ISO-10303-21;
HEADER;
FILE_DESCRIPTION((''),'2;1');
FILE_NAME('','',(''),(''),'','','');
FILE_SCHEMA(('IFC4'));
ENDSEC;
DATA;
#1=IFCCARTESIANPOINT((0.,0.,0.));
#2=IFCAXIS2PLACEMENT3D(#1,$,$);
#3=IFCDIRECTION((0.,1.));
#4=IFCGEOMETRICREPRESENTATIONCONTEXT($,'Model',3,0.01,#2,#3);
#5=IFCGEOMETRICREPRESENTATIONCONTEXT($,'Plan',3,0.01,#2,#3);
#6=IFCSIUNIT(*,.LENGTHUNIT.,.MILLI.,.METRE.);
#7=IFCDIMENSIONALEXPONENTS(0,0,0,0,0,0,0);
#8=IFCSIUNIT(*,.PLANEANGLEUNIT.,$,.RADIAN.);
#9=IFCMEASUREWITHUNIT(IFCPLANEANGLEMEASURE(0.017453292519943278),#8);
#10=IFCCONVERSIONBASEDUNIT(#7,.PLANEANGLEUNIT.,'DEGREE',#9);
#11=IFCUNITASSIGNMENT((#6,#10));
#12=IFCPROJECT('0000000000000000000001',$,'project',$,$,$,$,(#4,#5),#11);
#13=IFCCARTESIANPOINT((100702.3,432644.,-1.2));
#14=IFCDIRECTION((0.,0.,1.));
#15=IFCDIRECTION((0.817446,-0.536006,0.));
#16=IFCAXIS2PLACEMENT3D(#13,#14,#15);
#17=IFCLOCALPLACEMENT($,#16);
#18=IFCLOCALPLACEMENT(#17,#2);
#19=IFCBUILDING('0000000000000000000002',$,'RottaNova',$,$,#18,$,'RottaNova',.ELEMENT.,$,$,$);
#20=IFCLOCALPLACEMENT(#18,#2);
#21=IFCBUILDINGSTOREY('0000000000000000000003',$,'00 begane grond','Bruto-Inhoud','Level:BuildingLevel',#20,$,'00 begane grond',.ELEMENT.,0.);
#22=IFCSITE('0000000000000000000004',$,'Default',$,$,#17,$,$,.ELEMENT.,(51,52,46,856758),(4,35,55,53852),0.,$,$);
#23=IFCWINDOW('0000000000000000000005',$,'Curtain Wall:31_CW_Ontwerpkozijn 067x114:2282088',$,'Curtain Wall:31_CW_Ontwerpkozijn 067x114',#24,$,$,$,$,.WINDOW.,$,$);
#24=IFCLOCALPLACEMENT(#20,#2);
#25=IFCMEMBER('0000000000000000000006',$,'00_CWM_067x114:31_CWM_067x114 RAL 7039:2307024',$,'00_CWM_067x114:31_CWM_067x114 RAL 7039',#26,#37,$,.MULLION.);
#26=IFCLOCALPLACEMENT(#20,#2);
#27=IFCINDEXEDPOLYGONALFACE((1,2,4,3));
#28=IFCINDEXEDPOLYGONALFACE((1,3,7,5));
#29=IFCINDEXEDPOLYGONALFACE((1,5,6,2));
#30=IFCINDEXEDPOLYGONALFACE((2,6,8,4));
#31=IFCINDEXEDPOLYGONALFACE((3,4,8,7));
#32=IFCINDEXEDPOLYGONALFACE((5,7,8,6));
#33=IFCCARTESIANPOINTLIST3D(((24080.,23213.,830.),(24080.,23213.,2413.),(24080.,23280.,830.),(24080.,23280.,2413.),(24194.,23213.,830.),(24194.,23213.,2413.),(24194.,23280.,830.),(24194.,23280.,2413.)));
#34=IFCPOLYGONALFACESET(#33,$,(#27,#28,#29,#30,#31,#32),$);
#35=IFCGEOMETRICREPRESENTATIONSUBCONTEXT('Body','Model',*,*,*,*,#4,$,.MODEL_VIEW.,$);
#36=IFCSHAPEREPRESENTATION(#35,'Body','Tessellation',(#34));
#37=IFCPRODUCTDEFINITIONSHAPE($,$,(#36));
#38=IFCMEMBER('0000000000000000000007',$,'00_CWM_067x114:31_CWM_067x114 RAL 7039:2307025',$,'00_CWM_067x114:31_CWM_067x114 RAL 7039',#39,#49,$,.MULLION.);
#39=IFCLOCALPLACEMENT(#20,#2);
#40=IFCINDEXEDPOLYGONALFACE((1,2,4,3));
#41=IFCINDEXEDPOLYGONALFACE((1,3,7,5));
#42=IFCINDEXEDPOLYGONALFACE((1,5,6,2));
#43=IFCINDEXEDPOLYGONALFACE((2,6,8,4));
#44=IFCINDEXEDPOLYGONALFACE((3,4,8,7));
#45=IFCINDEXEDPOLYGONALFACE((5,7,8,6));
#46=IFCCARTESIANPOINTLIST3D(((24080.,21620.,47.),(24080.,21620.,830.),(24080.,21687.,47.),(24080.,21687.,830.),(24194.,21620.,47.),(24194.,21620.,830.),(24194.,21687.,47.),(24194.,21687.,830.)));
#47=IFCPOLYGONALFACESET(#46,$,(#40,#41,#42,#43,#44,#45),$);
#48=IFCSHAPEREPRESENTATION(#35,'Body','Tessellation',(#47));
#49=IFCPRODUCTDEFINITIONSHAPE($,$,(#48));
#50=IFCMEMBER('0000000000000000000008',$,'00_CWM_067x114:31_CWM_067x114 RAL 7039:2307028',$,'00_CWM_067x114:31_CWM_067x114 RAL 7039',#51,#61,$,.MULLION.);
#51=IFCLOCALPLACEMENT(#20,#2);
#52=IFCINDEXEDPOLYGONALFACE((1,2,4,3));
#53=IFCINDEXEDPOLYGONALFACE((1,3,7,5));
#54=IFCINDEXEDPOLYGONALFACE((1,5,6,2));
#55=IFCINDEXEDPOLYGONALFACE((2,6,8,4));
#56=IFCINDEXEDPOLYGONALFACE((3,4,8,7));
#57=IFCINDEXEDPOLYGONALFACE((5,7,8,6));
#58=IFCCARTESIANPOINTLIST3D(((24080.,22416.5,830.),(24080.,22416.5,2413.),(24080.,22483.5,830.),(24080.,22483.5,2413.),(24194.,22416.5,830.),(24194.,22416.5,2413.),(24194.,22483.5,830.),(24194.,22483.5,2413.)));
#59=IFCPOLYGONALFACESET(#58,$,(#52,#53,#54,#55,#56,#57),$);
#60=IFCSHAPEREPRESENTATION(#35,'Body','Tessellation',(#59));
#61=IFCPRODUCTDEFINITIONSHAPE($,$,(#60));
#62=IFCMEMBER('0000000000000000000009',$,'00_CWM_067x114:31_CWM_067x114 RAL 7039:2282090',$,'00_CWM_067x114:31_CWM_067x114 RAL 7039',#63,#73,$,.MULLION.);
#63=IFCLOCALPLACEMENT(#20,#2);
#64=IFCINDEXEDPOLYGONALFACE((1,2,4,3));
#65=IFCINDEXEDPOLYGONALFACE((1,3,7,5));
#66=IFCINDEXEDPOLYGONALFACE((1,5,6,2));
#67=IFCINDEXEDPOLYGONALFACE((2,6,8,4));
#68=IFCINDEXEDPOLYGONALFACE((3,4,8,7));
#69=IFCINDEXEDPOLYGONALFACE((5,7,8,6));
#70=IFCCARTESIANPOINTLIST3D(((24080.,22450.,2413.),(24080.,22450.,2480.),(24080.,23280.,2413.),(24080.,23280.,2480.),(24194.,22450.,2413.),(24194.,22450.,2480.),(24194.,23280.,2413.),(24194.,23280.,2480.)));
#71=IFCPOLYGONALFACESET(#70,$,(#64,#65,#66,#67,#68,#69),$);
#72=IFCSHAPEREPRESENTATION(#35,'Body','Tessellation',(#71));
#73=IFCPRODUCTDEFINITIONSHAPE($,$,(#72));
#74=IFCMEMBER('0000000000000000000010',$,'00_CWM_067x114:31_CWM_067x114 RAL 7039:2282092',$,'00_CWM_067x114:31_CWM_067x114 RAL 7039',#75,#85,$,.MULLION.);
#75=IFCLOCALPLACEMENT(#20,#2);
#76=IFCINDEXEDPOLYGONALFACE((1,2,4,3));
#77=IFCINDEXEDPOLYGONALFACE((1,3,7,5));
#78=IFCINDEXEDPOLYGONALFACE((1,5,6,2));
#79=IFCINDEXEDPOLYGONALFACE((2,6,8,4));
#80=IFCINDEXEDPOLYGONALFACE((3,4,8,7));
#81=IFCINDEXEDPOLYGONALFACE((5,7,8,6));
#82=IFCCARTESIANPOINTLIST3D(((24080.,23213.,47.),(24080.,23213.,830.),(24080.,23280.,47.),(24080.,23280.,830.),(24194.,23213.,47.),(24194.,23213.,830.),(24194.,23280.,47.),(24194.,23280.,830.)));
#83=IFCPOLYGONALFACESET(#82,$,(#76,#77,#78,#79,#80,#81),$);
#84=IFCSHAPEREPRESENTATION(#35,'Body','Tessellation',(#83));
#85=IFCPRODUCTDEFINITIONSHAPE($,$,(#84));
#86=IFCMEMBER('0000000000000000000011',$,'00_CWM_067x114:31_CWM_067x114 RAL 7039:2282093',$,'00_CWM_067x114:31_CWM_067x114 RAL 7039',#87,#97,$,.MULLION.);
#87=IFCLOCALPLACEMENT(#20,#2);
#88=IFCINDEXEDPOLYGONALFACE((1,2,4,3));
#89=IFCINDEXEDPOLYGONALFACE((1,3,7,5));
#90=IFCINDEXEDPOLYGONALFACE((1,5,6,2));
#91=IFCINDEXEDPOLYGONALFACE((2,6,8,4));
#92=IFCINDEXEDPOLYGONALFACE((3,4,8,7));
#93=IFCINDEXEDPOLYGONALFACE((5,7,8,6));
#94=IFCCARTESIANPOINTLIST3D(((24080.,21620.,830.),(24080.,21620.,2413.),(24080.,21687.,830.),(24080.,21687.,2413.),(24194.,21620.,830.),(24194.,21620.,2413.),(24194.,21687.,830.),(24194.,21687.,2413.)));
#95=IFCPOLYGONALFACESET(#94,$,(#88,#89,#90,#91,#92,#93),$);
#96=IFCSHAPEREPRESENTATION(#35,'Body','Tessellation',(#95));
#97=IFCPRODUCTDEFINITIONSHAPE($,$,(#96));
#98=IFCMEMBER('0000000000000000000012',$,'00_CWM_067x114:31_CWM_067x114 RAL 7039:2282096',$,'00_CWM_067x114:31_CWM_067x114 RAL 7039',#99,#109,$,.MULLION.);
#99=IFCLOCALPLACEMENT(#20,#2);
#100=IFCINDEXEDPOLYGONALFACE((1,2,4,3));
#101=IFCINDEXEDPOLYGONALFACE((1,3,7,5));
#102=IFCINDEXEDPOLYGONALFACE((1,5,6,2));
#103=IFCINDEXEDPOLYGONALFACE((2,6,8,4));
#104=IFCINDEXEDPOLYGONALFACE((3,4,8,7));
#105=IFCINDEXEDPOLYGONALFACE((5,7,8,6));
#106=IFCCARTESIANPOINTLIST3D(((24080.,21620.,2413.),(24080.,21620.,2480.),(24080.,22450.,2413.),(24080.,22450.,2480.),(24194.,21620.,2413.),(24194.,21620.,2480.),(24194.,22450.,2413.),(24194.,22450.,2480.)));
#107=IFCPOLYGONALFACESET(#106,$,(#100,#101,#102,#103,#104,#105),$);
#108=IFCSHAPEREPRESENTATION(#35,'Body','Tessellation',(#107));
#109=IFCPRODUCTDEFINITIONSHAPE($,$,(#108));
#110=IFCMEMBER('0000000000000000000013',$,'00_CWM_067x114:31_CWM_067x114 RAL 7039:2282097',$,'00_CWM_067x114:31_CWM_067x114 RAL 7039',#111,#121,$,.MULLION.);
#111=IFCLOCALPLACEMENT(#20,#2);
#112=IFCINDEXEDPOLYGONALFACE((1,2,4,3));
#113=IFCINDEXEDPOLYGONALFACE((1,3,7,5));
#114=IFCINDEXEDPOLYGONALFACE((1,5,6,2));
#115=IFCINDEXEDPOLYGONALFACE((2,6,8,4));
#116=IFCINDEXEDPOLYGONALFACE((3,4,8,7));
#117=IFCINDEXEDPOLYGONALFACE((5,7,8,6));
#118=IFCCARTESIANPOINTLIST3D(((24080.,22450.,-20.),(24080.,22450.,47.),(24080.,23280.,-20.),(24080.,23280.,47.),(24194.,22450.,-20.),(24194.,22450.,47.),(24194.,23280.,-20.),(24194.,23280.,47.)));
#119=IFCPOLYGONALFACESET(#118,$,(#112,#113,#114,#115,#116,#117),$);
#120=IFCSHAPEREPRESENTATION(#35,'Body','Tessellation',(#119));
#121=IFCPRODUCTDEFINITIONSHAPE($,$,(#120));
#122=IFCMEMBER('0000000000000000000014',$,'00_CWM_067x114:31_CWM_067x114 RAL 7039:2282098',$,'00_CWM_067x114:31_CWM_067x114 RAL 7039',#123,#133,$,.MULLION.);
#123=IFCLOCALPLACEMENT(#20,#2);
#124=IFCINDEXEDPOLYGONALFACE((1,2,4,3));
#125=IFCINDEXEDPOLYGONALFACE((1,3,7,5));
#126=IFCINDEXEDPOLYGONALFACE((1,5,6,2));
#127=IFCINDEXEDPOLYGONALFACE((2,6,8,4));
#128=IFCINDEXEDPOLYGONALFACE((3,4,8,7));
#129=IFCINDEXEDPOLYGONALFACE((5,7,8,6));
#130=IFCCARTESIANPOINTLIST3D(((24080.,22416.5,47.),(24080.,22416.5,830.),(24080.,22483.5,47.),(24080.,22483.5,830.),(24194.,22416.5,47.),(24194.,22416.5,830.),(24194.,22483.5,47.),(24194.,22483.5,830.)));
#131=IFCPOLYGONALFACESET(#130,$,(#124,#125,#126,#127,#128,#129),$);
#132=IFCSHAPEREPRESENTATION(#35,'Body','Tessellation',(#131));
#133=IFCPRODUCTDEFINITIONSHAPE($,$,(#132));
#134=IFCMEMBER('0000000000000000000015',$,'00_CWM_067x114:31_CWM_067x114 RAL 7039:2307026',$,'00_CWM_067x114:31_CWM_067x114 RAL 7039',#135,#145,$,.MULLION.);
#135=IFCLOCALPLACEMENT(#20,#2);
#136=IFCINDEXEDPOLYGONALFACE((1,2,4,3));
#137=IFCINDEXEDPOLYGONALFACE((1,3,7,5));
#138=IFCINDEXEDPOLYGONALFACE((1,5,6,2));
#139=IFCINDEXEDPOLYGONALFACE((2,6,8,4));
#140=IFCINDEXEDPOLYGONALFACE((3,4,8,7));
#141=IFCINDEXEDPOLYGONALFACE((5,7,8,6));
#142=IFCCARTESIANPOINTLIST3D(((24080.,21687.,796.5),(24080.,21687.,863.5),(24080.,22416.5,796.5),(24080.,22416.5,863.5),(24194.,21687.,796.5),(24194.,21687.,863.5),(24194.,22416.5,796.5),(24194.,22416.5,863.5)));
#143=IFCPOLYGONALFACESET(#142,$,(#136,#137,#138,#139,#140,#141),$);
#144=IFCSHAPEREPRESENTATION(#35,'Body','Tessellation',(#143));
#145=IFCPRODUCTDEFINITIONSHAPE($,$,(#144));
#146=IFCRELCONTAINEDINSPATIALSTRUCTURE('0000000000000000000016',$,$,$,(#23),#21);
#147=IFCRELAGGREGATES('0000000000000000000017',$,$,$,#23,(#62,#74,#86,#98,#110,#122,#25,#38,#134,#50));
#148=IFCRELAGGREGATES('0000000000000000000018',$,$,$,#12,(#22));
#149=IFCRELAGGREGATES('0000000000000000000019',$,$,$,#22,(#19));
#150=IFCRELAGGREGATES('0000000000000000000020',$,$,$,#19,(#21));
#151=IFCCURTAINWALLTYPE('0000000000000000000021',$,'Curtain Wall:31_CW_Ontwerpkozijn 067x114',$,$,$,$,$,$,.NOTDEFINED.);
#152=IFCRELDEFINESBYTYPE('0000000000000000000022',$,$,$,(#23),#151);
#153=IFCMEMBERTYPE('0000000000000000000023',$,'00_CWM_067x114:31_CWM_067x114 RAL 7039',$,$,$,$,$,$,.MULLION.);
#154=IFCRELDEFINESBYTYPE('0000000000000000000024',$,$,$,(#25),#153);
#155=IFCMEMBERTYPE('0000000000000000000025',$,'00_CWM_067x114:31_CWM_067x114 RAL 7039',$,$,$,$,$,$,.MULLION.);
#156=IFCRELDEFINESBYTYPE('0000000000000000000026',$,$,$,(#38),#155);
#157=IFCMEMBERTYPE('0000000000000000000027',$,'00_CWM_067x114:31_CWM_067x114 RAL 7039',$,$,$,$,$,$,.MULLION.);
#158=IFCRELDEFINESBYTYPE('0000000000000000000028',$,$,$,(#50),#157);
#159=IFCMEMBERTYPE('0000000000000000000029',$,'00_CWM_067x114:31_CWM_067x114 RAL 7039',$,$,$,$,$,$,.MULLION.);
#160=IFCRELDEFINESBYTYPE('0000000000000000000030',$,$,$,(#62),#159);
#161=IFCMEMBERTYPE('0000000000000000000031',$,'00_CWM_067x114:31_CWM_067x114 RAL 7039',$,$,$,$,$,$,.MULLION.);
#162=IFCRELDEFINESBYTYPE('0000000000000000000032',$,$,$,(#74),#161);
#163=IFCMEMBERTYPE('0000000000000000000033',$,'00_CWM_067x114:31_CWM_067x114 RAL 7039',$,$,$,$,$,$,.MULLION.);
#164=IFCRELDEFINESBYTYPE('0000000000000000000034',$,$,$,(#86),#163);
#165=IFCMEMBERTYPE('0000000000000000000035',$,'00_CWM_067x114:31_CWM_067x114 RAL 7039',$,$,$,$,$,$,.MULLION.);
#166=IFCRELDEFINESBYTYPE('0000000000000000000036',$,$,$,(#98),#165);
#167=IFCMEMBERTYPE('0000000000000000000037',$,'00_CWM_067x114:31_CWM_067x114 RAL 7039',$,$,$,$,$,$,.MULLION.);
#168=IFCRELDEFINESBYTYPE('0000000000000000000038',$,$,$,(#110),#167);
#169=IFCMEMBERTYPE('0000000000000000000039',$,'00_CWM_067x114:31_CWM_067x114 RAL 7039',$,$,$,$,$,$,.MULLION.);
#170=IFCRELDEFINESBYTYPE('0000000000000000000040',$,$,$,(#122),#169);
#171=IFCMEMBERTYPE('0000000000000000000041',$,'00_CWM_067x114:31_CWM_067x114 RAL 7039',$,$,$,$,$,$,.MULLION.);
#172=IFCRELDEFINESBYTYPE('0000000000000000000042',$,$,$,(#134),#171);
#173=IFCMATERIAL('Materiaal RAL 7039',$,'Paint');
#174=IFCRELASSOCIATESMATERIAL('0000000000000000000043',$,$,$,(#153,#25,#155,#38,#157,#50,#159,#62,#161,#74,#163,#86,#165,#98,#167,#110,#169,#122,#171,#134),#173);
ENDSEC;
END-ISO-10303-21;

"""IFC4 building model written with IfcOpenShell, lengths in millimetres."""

from ifc_helpers import new_model, entity, si_unit, converted_unit, direction, frame, origin, place, context, subcontext, project, spatial, indexed_curve, outline, extrude, source, transform, mapped, material, type_object, type_shapes, element, aggregate, save


model = new_model("IFC4")

# Units and contexts
model_context = context("Model", 3, precision=0.01, world=origin(), true_north=direction((0.0, 1.0)))
plan_context = context("Plan", 3, precision=0.01, world=origin(), true_north=direction((0.0, 1.0)))
body_context = subcontext(model_context, "Body", "Model", "MODEL_VIEW")
ifc_project = project(units=[si_unit("LENGTHUNIT", "METRE", prefix="MILLI"), converted_unit("PLANEANGLEUNIT", "DEGREE", entity("IfcPlaneAngleMeasure", 0.017453292519943278), si_unit("PLANEANGLEUNIT", "RADIAN"), dimensions=[0, 0, 0, 0, 0, 0, 0])], contexts=[model_context, plan_context])

# Site, building, storey
site_placement = place(None, frame((100702.3, 432644.0, -1.2), z_axis=(0.0, 0.0, 1.0), x_axis=(0.817446, -0.536006, 0.0)))
site = spatial("IfcSite", under=ifc_project, at=site_placement, Name="Default", CompositionType="ELEMENT", RefLatitude=(51, 52, 46, 856758), RefLongitude=(4, 35, 55, 53852), RefElevation=0.0)
building_placement = place(site_placement, origin())
building = spatial("IfcBuilding", under=site, at=building_placement, Name="RottaNova", LongName="RottaNova", CompositionType="ELEMENT")
storey_placement = place(building_placement, origin())
storey = spatial("IfcBuildingStorey", under=building, at=storey_placement, Name="00 begane grond", Description="Bruto-Inhoud", ObjectType="Level:BuildingLevel", LongName="00 begane grond", CompositionType="ELEMENT", Elevation=0.0)

# Window, members
curtain_wall_type = type_object("IfcCurtainWallType", Name="Curtain Wall:31_CW_Ontwerpkozijn 067x114", PredefinedType="NOTDEFINED")
window_placement = place(storey_placement, origin())
window = element("IfcWindow", 1, at=window_placement, inside=storey, type_object=curtain_wall_type, Name="Curtain Wall:31_CW_Ontwerpkozijn 067x114:2282088", ObjectType="Curtain Wall:31_CW_Ontwerpkozijn 067x114", PredefinedType="WINDOW")
ifc_material_1 = material(Name="Materiaal RAL 7039", Category="Paint")
member_type_1 = type_object("IfcMemberType", Name="00_CWM_067x114:31_CWM_067x114 RAL 7039", PredefinedType="MULLION", material=ifc_material_1)
shared_shape_1 = source(origin(), body_context, "Body", "SweptSolid", [
    extrude(outline(indexed_curve([(-33.5, -57.0), (33.5, -57.0), (33.5, 57.0), (-33.5, 57.0), (-33.5, -57.0)], self_intersect=False)), frame((-33.5, 57.0, -1583.0), z_axis=(0.0, 0.0, 1.0), x_axis=(-1.0, 0.0, 0.0)), (0.0, 0.0, 1.0), 1583.0),
])
type_shapes(member_type_1, [shared_shape_1])
member_1_placement = place(window_placement, frame((24080.0, 23280.0, 830.0), z_axis=(0.0, 0.0, -1.0), x_axis=(0.0, 1.0, 0.0)))
member_1 = element("IfcMember", 2, at=member_1_placement, type_object=member_type_1, material=ifc_material_1, Name="00_CWM_067x114:31_CWM_067x114 RAL 7039:2307024", ObjectType="00_CWM_067x114:31_CWM_067x114 RAL 7039", PredefinedType="MULLION", context=body_context, shape_type="MappedRepresentation", body=[
    mapped(shared_shape_1, transform((0.0, 0.0, 0.0), scale=1.0)),
])
member_type_2 = type_object("IfcMemberType", Name="00_CWM_067x114:31_CWM_067x114 RAL 7039", PredefinedType="MULLION", material=ifc_material_1)
shared_shape_2 = source(origin(), body_context, "Body", "SweptSolid", [
    extrude(outline(indexed_curve([(-33.5, -57.0), (33.5, -57.0), (33.5, 57.0), (-33.5, 57.0), (-33.5, -57.0)], self_intersect=False)), frame((-33.5, 57.0, -783.0), z_axis=(0.0, 0.0, 1.0), x_axis=(-1.0, 0.0, 0.0)), (0.0, 0.0, 1.0), 783.0),
])
type_shapes(member_type_2, [shared_shape_2])
member_2_placement = place(window_placement, frame((24080.0, 21620.0, 830.0), z_axis=(0.0, 0.0, 1.0), x_axis=(0.0, -1.0, 0.0)))
member_2 = element("IfcMember", 3, at=member_2_placement, type_object=member_type_2, material=ifc_material_1, Name="00_CWM_067x114:31_CWM_067x114 RAL 7039:2307025", ObjectType="00_CWM_067x114:31_CWM_067x114 RAL 7039", PredefinedType="MULLION", context=body_context, shape_type="MappedRepresentation", body=[
    mapped(shared_shape_2, transform((0.0, 0.0, 0.0), scale=1.0)),
])
member_type_3 = type_object("IfcMemberType", Name="00_CWM_067x114:31_CWM_067x114 RAL 7039", PredefinedType="MULLION", material=ifc_material_1)
shared_shape_3 = source(origin(), body_context, "Body", "SweptSolid", [
    extrude(outline(indexed_curve([(-33.5, -57.0), (33.5, -57.0), (33.5, 57.0), (-33.5, 57.0), (-33.5, -57.0)], self_intersect=False)), frame((0.0, 57.0, -1583.0), z_axis=(0.0, 0.0, 1.0), x_axis=(-1.0, 0.0, 0.0)), (0.0, 0.0, 1.0), 1583.0),
])
type_shapes(member_type_3, [shared_shape_3])
member_3_placement = place(window_placement, frame((24080.0, 22450.0, 830.0), z_axis=(0.0, 0.0, -1.0), x_axis=(0.0, 1.0, 0.0)))
member_3 = element("IfcMember", 4, at=member_3_placement, type_object=member_type_3, material=ifc_material_1, Name="00_CWM_067x114:31_CWM_067x114 RAL 7039:2307028", ObjectType="00_CWM_067x114:31_CWM_067x114 RAL 7039", PredefinedType="MULLION", context=body_context, shape_type="MappedRepresentation", body=[
    mapped(shared_shape_3, transform((0.0, 0.0, 0.0), scale=1.0)),
])
member_type_4 = type_object("IfcMemberType", Name="00_CWM_067x114:31_CWM_067x114 RAL 7039", PredefinedType="MULLION", material=ifc_material_1)
shared_shape_4 = source(origin(), body_context, "Body", "SweptSolid", [
    extrude(outline(indexed_curve([(-33.5, -57.0), (33.5, -57.0), (33.5, 57.0), (-33.5, 57.0), (-33.5, -57.0)], self_intersect=False)), frame((-33.5, 57.0, -830.0), z_axis=(0.0, 0.0, 1.0), x_axis=(-1.0, 0.0, 0.0)), (0.0, 0.0, 1.0), 830.0),
])
type_shapes(member_type_4, [shared_shape_4])
member_4_placement = place(window_placement, frame((24080.0, 23280.0, 2480.0), z_axis=(0.0, 1.0, 0.0), x_axis=(0.0, 0.0, 1.0)))
member_4 = element("IfcMember", 5, at=member_4_placement, type_object=member_type_4, material=ifc_material_1, Name="00_CWM_067x114:31_CWM_067x114 RAL 7039:2282090", ObjectType="00_CWM_067x114:31_CWM_067x114 RAL 7039", PredefinedType="MULLION", context=body_context, shape_type="MappedRepresentation", body=[
    mapped(shared_shape_4, transform((0.0, 0.0, 0.0), scale=1.0)),
])
member_type_5 = type_object("IfcMemberType", Name="00_CWM_067x114:31_CWM_067x114 RAL 7039", PredefinedType="MULLION", material=ifc_material_1)
shared_shape_5 = source(origin(), body_context, "Body", "SweptSolid", [
    extrude(outline(indexed_curve([(-33.5, -57.0), (33.5, -57.0), (33.5, 57.0), (-33.5, 57.0), (-33.5, -57.0)], self_intersect=False)), frame((-33.5, 57.0, -783.0), z_axis=(0.0, 0.0, 1.0), x_axis=(-1.0, 0.0, 0.0)), (0.0, 0.0, 1.0), 783.0),
])
type_shapes(member_type_5, [shared_shape_5])
member_5_placement = place(window_placement, frame((24080.0, 23280.0, 47.0), z_axis=(0.0, 0.0, -1.0), x_axis=(0.0, 1.0, 0.0)))
member_5 = element("IfcMember", 6, at=member_5_placement, type_object=member_type_5, material=ifc_material_1, Name="00_CWM_067x114:31_CWM_067x114 RAL 7039:2282092", ObjectType="00_CWM_067x114:31_CWM_067x114 RAL 7039", PredefinedType="MULLION", context=body_context, shape_type="MappedRepresentation", body=[
    mapped(shared_shape_5, transform((0.0, 0.0, 0.0), scale=1.0)),
])
member_type_6 = type_object("IfcMemberType", Name="00_CWM_067x114:31_CWM_067x114 RAL 7039", PredefinedType="MULLION", material=ifc_material_1)
shared_shape_6 = source(origin(), body_context, "Body", "SweptSolid", [
    extrude(outline(indexed_curve([(-33.5, -57.0), (33.5, -57.0), (33.5, 57.0), (-33.5, 57.0), (-33.5, -57.0)], self_intersect=False)), frame((-33.5, 57.0, -1583.0), z_axis=(0.0, 0.0, 1.0), x_axis=(-1.0, 0.0, 0.0)), (0.0, 0.0, 1.0), 1583.0),
])
type_shapes(member_type_6, [shared_shape_6])
member_6_placement = place(window_placement, frame((24080.0, 21620.0, 2413.0), z_axis=(0.0, 0.0, 1.0), x_axis=(0.0, -1.0, 0.0)))
member_6 = element("IfcMember", 7, at=member_6_placement, type_object=member_type_6, material=ifc_material_1, Name="00_CWM_067x114:31_CWM_067x114 RAL 7039:2282093", ObjectType="00_CWM_067x114:31_CWM_067x114 RAL 7039", PredefinedType="MULLION", context=body_context, shape_type="MappedRepresentation", body=[
    mapped(shared_shape_6, transform((0.0, 0.0, 0.0), scale=1.0)),
])
member_type_7 = type_object("IfcMemberType", Name="00_CWM_067x114:31_CWM_067x114 RAL 7039", PredefinedType="MULLION", material=ifc_material_1)
shared_shape_7 = source(origin(), body_context, "Body", "SweptSolid", [
    extrude(outline(indexed_curve([(-33.5, -57.0), (33.5, -57.0), (33.5, 57.0), (-33.5, 57.0), (-33.5, -57.0)], self_intersect=False)), frame((-33.5, 57.0, -830.0), z_axis=(0.0, 0.0, 1.0), x_axis=(-1.0, 0.0, 0.0)), (0.0, 0.0, 1.0), 830.0),
])
type_shapes(member_type_7, [shared_shape_7])
member_7_placement = place(window_placement, frame((24080.0, 22450.0, 2480.0), z_axis=(0.0, 1.0, 0.0), x_axis=(0.0, 0.0, 1.0)))
member_7 = element("IfcMember", 8, at=member_7_placement, type_object=member_type_7, material=ifc_material_1, Name="00_CWM_067x114:31_CWM_067x114 RAL 7039:2282096", ObjectType="00_CWM_067x114:31_CWM_067x114 RAL 7039", PredefinedType="MULLION", context=body_context, shape_type="MappedRepresentation", body=[
    mapped(shared_shape_7, transform((0.0, 0.0, 0.0), scale=1.0)),
])
member_type_8 = type_object("IfcMemberType", Name="00_CWM_067x114:31_CWM_067x114 RAL 7039", PredefinedType="MULLION", material=ifc_material_1)
shared_shape_8 = source(origin(), body_context, "Body", "SweptSolid", [
    extrude(outline(indexed_curve([(-33.5, -57.0), (33.5, -57.0), (33.5, 57.0), (-33.5, 57.0), (-33.5, -57.0)], self_intersect=False)), frame((-33.5, 57.0, -830.0), z_axis=(0.0, 0.0, 1.0), x_axis=(-1.0, 0.0, 0.0)), (0.0, 0.0, 1.0), 830.0),
])
type_shapes(member_type_8, [shared_shape_8])
member_8_placement = place(window_placement, frame((24080.0, 22450.0, -20.0), z_axis=(0.0, -1.0, 0.0), x_axis=(0.0, 0.0, -1.0)))
member_8 = element("IfcMember", 9, at=member_8_placement, type_object=member_type_8, material=ifc_material_1, Name="00_CWM_067x114:31_CWM_067x114 RAL 7039:2282097", ObjectType="00_CWM_067x114:31_CWM_067x114 RAL 7039", PredefinedType="MULLION", context=body_context, shape_type="MappedRepresentation", body=[
    mapped(shared_shape_8, transform((0.0, 0.0, 0.0), scale=1.0)),
])
member_type_9 = type_object("IfcMemberType", Name="00_CWM_067x114:31_CWM_067x114 RAL 7039", PredefinedType="MULLION", material=ifc_material_1)
shared_shape_9 = source(origin(), body_context, "Body", "SweptSolid", [
    extrude(outline(indexed_curve([(-33.5, -57.0), (33.5, -57.0), (33.5, 57.0), (-33.5, 57.0), (-33.5, -57.0)], self_intersect=False)), frame((0.0, 57.0, -783.0), z_axis=(0.0, 0.0, 1.0), x_axis=(-1.0, 0.0, 0.0)), (0.0, 0.0, 1.0), 783.0),
])
type_shapes(member_type_9, [shared_shape_9])
member_9_placement = place(window_placement, frame((24080.0, 22450.0, 47.0), z_axis=(0.0, 0.0, -1.0), x_axis=(0.0, 1.0, 0.0)))
member_9 = element("IfcMember", 10, at=member_9_placement, type_object=member_type_9, material=ifc_material_1, Name="00_CWM_067x114:31_CWM_067x114 RAL 7039:2282098", ObjectType="00_CWM_067x114:31_CWM_067x114 RAL 7039", PredefinedType="MULLION", context=body_context, shape_type="MappedRepresentation", body=[
    mapped(shared_shape_9, transform((0.0, 0.0, 0.0), scale=1.0)),
])
member_type_10 = type_object("IfcMemberType", Name="00_CWM_067x114:31_CWM_067x114 RAL 7039", PredefinedType="MULLION", material=ifc_material_1)
shared_shape_10 = source(origin(), body_context, "Body", "SweptSolid", [
    extrude(outline(indexed_curve([(-33.5, -57.0), (33.5, -57.0), (33.5, 57.0), (-33.5, 57.0), (-33.5, -57.0)], self_intersect=False)), frame((0.0, 57.0, -729.5), z_axis=(0.0, 0.0, 1.0), x_axis=(-1.0, 0.0, 0.0)), (0.0, 0.0, 1.0), 729.5),
])
type_shapes(member_type_10, [shared_shape_10])
member_10_placement = place(window_placement, frame((24080.0, 22416.5, 830.0), z_axis=(0.0, 1.0, 0.0), x_axis=(0.0, 0.0, 1.0)))
member_10 = element("IfcMember", 11, at=member_10_placement, type_object=member_type_10, material=ifc_material_1, Name="00_CWM_067x114:31_CWM_067x114 RAL 7039:2307026", ObjectType="00_CWM_067x114:31_CWM_067x114 RAL 7039", PredefinedType="MULLION", context=body_context, shape_type="MappedRepresentation", body=[
    mapped(shared_shape_10, transform((0.0, 0.0, 0.0), scale=1.0)),
])
aggregate(window, [member_4, member_5, member_6, member_7, member_8, member_9, member_1, member_2, member_10, member_3])

save(model, "model.ifc")
